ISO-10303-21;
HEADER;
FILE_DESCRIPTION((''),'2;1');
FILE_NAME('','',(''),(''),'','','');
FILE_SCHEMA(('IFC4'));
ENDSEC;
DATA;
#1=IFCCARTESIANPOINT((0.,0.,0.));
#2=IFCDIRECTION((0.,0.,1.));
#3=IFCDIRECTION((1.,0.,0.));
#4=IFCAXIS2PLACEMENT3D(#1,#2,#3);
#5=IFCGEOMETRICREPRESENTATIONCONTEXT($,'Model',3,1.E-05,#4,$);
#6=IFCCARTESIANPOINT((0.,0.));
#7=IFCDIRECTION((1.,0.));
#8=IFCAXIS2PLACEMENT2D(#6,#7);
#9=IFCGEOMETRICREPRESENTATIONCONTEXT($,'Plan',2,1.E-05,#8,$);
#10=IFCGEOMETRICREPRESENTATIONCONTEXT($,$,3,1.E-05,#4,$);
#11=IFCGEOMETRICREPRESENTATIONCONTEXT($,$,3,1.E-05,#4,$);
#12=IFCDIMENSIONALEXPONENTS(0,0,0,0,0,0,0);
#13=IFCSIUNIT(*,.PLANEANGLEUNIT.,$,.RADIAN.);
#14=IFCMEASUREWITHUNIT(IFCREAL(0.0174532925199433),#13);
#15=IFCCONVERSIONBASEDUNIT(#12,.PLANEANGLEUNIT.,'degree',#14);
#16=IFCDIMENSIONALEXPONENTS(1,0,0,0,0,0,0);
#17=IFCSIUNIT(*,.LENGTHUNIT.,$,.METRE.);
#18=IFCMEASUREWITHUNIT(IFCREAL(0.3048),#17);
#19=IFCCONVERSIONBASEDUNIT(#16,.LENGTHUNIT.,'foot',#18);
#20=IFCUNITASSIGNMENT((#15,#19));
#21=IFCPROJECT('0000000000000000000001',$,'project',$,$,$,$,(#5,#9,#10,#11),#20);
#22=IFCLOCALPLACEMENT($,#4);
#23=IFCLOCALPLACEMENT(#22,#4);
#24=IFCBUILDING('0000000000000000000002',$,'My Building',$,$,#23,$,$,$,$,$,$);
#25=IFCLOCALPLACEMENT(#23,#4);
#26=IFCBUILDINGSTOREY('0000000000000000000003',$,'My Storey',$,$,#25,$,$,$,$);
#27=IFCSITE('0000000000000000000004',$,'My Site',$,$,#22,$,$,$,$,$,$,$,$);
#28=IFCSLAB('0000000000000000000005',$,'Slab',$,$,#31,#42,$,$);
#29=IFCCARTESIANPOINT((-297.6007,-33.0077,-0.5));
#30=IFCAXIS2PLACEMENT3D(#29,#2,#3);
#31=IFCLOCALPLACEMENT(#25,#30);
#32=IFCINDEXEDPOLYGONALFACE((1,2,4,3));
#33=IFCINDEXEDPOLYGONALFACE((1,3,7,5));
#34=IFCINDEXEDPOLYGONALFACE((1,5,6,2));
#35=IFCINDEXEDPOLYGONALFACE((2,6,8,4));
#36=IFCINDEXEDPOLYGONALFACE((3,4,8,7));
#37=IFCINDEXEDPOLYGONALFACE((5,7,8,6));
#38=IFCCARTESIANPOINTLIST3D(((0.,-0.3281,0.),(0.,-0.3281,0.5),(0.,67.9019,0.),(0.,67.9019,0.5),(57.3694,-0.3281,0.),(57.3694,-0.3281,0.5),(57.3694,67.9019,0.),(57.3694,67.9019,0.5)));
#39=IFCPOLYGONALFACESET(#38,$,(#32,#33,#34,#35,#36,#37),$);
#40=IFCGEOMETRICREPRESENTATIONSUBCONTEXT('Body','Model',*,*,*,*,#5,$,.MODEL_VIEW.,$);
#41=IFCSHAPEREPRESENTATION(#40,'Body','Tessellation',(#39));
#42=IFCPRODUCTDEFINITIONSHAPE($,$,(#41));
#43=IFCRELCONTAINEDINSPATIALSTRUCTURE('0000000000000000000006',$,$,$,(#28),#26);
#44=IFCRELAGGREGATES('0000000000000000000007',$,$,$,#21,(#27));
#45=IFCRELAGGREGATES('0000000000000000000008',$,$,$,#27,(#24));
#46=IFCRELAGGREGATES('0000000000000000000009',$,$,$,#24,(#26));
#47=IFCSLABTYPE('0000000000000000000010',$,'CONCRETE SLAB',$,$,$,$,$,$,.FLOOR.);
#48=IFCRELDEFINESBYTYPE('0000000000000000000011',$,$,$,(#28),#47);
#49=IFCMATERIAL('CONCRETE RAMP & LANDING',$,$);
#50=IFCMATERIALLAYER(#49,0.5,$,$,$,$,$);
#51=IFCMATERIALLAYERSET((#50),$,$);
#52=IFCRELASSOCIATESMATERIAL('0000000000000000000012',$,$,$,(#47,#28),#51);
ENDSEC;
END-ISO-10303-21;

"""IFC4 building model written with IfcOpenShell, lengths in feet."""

from ifc_helpers import new_model, entity, si_unit, converted_unit, frame, origin_with_axes, origin_2d_with_axis, place, context, subcontext, project, spatial, line, indexed_curve, outline, extrude, material, layer, layer_set, layer_usage, type_object, element, save


model = new_model("IFC4")

# Units and contexts
model_context = context("Model", 3, precision=1e-05, world=origin_with_axes())
plan_context = context("Plan", 2, precision=1e-05, world=origin_2d_with_axis())
context_of_model_1 = context(None, 3, precision=1e-05, world=origin_with_axes())
context_of_model_2 = context(None, 3, precision=1e-05, world=origin_with_axes())
body_context = subcontext(model_context, "Body", "Model", "MODEL_VIEW")
ifc_project = project(units=[converted_unit("PLANEANGLEUNIT", "degree", entity("IfcReal", 0.0174532925199433), si_unit("PLANEANGLEUNIT", "RADIAN"), dimensions=[0, 0, 0, 0, 0, 0, 0]), converted_unit("LENGTHUNIT", "foot", entity("IfcReal", 0.3048), si_unit("LENGTHUNIT", "METRE"), dimensions=[1, 0, 0, 0, 0, 0, 0])], contexts=[model_context, plan_context, context_of_model_1, context_of_model_2])

# Site, building, storey
site_placement = place(None, origin_with_axes())
site = spatial("IfcSite", under=ifc_project, at=site_placement, Name="My Site")
building_placement = place(site_placement, origin_with_axes())
building = spatial("IfcBuilding", under=site, at=building_placement, Name="My Building")
storey_placement = place(building_placement, origin_with_axes())
storey = spatial("IfcBuildingStorey", under=building, at=storey_placement, Name="My Storey")

# Slab
ifc_material_1 = material(Name="CONCRETE RAMP & LANDING")
ifc_layer_1 = layer(ifc_material_1, 0.5)
ifc_layer_set_1 = layer_set([ifc_layer_1])
ifc_layer_usage_1 = layer_usage(ifc_layer_set_1, "AXIS3", "POSITIVE", 0.0)
slab_type = type_object("IfcSlabType", Name="CONCRETE SLAB", PredefinedType="FLOOR", material=ifc_layer_set_1)
slab_placement = place(storey_placement, frame((-297.6007, -33.0077, -0.5), z_axis=(0.0, 0.0, 1.0), x_axis=(1.0, 0.0, 0.0)))
element("IfcSlab", 1, at=slab_placement, inside=storey, type_object=slab_type, material=ifc_layer_usage_1, Name="Slab", context=body_context, shape_type="SweptSolid", body=[
    extrude(outline(indexed_curve([(0.0, 67.9019), (0.0, -0.3281), (57.3694, -0.3281), (57.3694, 67.9019)], segments=[line(3, 2), line(2, 1), line(1, 4), line(4, 3)], self_intersect=False)), None, (0.0, 0.0, 1.0), 0.5),
])

save(model, "model.ifc")
